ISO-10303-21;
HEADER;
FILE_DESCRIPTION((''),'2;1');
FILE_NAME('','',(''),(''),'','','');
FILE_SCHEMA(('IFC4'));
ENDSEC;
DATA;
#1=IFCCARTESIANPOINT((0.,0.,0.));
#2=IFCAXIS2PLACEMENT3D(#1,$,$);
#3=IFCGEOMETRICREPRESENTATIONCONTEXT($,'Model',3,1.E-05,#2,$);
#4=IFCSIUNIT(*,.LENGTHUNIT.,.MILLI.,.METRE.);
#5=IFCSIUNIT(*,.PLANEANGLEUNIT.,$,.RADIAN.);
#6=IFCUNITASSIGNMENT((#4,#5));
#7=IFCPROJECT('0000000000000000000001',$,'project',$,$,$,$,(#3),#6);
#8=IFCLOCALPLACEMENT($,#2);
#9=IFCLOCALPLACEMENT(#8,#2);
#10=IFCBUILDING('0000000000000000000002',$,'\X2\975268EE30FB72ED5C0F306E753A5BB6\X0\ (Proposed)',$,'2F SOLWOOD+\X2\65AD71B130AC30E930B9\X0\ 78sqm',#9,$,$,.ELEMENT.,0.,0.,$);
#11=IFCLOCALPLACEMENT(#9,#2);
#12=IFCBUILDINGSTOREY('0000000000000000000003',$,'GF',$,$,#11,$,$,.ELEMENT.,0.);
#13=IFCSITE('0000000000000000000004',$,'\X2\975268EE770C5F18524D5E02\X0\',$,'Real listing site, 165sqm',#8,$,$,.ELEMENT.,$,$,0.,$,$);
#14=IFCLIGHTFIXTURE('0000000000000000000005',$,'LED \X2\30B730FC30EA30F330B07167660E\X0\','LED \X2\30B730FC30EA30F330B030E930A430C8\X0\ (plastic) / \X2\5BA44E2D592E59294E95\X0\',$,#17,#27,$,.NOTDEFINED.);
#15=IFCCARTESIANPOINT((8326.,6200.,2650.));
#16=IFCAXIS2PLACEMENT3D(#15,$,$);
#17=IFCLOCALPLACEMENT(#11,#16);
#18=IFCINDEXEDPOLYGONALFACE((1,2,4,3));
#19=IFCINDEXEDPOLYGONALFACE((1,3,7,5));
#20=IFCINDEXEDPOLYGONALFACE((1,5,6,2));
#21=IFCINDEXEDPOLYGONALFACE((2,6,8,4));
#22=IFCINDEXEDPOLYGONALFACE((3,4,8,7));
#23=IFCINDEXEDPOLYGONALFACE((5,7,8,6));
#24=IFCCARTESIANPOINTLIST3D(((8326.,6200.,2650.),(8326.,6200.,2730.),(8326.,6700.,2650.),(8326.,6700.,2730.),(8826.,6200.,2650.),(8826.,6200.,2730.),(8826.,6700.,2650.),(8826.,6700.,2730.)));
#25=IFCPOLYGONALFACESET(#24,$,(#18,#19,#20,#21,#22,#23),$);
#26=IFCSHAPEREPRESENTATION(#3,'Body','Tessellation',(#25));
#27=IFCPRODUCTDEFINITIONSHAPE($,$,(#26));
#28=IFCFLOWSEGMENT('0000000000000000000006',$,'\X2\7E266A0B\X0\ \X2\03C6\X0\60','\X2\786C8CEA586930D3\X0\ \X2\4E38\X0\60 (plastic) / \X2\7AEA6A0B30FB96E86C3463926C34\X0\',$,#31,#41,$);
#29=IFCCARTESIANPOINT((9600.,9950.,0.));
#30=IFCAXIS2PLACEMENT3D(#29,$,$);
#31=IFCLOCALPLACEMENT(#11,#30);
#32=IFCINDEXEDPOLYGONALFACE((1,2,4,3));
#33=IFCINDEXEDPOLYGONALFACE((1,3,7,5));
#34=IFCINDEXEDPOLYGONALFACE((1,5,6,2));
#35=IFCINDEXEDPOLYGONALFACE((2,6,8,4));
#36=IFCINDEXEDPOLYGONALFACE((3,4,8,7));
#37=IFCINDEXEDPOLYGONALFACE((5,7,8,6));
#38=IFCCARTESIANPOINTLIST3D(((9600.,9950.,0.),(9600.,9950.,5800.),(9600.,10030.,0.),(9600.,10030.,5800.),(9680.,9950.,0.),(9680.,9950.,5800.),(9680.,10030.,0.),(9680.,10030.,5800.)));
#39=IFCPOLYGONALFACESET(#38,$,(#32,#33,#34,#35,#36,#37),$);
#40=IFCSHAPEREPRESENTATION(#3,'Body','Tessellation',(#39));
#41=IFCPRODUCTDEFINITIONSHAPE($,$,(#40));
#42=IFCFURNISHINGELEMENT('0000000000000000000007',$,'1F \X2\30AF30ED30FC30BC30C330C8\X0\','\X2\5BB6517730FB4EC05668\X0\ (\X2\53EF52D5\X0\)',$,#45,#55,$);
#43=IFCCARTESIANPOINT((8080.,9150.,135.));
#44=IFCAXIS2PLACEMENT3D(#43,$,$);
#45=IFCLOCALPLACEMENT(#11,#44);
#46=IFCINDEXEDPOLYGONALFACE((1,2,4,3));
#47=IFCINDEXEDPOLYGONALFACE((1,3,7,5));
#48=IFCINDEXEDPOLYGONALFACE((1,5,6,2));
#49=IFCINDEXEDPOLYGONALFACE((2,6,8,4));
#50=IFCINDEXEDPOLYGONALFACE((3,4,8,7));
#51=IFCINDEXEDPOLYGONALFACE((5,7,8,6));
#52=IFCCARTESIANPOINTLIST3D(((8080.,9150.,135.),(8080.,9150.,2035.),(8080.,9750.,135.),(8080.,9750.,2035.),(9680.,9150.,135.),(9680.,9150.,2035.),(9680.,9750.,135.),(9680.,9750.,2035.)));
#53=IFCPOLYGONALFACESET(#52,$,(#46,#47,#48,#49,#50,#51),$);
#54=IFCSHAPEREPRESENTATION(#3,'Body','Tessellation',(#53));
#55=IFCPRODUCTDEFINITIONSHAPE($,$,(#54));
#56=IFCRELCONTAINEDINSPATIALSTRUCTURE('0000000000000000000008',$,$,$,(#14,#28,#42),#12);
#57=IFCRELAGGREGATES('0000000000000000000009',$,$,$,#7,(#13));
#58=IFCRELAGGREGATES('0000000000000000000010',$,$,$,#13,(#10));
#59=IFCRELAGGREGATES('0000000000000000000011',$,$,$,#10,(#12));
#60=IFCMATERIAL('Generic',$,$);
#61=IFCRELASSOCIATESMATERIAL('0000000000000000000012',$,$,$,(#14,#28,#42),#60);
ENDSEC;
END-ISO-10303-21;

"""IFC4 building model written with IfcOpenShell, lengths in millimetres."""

from ifc_helpers import new_model, si_unit, frame, frame_2d, origin, place, context, project, spatial, rectangle, extrude, material, element, save


model = new_model("IFC4")

# Units and contexts
model_context = context("Model", 3, precision=1e-05, world=origin())
ifc_project = project(units=[si_unit("LENGTHUNIT", "METRE", prefix="MILLI"), si_unit("PLANEANGLEUNIT", "RADIAN")], contexts=[model_context])

# Site, building, storey
site_placement = place(None, origin())
site = spatial("IfcSite", under=ifc_project, at=site_placement, Name="青森県弘前市", ObjectType="Real listing site, 165sqm", CompositionType="ELEMENT", RefElevation=0.0)
building_placement = place(site_placement, origin())
building = spatial("IfcBuilding", under=site, at=building_placement, Name="青森・狭小の町家 (Proposed)", ObjectType="2F SOLWOOD+断熱ガラス 78sqm", CompositionType="ELEMENT", ElevationOfRefHeight=0.0, ElevationOfTerrain=0.0)
storey_placement = place(building_placement, origin())
storey = spatial("IfcBuildingStorey", under=building, at=storey_placement, Name="GF", CompositionType="ELEMENT", Elevation=0.0)

# Shared definitions
ifc_material_1 = material(Name="Generic")

# Light fixture
light_fixture_placement = place(storey_placement, frame((8326.0, 6200.0, 2650.0)))
element("IfcLightFixture", 1, at=light_fixture_placement, inside=storey, material=ifc_material_1, Name="LED シーリング照明", Description="LED シーリングライト (plastic) / 室中央天井", PredefinedType="NOTDEFINED", context=model_context, shape_type="SweptSolid", body=[
    extrude(rectangle(XDim=500.0, YDim=500.0, at=frame_2d((250.0, 250.0))), frame((8326.0, 6200.0, 2650.0)), (0.0, 0.0, 1.0), 80.0),
])

# Flow segment
flow_segment_placement = place(storey_placement, frame((9600.0, 9950.0, 0.0)))
element("IfcFlowSegment", 2, at=flow_segment_placement, inside=storey, material=ifc_material_1, Name="縦樋 φ60", Description="硬質塩ビ 丸60 (plastic) / 竪樋・雨水排水", context=model_context, shape_type="SweptSolid", body=[
    extrude(rectangle(XDim=80.0, YDim=80.0, at=frame_2d((40.0, 40.0))), frame((9600.0, 9950.0, 0.0)), (0.0, 0.0, 1.0), 5800.0),
])

# Furnishing element
furnishing_placement = place(storey_placement, frame((8080.0, 9150.0, 135.0)))
element("IfcFurnishingElement", 3, at=furnishing_placement, inside=storey, material=ifc_material_1, Name="1F クローゼット", Description="家具・什器 (可動)", context=model_context, shape_type="SweptSolid", body=[
    extrude(rectangle(XDim=1600.0, YDim=600.0, at=frame_2d((800.0, 300.0))), frame((8080.0, 9150.0, 135.0)), (0.0, 0.0, 1.0), 1900.0),
])

save(model, "model.ifc")
